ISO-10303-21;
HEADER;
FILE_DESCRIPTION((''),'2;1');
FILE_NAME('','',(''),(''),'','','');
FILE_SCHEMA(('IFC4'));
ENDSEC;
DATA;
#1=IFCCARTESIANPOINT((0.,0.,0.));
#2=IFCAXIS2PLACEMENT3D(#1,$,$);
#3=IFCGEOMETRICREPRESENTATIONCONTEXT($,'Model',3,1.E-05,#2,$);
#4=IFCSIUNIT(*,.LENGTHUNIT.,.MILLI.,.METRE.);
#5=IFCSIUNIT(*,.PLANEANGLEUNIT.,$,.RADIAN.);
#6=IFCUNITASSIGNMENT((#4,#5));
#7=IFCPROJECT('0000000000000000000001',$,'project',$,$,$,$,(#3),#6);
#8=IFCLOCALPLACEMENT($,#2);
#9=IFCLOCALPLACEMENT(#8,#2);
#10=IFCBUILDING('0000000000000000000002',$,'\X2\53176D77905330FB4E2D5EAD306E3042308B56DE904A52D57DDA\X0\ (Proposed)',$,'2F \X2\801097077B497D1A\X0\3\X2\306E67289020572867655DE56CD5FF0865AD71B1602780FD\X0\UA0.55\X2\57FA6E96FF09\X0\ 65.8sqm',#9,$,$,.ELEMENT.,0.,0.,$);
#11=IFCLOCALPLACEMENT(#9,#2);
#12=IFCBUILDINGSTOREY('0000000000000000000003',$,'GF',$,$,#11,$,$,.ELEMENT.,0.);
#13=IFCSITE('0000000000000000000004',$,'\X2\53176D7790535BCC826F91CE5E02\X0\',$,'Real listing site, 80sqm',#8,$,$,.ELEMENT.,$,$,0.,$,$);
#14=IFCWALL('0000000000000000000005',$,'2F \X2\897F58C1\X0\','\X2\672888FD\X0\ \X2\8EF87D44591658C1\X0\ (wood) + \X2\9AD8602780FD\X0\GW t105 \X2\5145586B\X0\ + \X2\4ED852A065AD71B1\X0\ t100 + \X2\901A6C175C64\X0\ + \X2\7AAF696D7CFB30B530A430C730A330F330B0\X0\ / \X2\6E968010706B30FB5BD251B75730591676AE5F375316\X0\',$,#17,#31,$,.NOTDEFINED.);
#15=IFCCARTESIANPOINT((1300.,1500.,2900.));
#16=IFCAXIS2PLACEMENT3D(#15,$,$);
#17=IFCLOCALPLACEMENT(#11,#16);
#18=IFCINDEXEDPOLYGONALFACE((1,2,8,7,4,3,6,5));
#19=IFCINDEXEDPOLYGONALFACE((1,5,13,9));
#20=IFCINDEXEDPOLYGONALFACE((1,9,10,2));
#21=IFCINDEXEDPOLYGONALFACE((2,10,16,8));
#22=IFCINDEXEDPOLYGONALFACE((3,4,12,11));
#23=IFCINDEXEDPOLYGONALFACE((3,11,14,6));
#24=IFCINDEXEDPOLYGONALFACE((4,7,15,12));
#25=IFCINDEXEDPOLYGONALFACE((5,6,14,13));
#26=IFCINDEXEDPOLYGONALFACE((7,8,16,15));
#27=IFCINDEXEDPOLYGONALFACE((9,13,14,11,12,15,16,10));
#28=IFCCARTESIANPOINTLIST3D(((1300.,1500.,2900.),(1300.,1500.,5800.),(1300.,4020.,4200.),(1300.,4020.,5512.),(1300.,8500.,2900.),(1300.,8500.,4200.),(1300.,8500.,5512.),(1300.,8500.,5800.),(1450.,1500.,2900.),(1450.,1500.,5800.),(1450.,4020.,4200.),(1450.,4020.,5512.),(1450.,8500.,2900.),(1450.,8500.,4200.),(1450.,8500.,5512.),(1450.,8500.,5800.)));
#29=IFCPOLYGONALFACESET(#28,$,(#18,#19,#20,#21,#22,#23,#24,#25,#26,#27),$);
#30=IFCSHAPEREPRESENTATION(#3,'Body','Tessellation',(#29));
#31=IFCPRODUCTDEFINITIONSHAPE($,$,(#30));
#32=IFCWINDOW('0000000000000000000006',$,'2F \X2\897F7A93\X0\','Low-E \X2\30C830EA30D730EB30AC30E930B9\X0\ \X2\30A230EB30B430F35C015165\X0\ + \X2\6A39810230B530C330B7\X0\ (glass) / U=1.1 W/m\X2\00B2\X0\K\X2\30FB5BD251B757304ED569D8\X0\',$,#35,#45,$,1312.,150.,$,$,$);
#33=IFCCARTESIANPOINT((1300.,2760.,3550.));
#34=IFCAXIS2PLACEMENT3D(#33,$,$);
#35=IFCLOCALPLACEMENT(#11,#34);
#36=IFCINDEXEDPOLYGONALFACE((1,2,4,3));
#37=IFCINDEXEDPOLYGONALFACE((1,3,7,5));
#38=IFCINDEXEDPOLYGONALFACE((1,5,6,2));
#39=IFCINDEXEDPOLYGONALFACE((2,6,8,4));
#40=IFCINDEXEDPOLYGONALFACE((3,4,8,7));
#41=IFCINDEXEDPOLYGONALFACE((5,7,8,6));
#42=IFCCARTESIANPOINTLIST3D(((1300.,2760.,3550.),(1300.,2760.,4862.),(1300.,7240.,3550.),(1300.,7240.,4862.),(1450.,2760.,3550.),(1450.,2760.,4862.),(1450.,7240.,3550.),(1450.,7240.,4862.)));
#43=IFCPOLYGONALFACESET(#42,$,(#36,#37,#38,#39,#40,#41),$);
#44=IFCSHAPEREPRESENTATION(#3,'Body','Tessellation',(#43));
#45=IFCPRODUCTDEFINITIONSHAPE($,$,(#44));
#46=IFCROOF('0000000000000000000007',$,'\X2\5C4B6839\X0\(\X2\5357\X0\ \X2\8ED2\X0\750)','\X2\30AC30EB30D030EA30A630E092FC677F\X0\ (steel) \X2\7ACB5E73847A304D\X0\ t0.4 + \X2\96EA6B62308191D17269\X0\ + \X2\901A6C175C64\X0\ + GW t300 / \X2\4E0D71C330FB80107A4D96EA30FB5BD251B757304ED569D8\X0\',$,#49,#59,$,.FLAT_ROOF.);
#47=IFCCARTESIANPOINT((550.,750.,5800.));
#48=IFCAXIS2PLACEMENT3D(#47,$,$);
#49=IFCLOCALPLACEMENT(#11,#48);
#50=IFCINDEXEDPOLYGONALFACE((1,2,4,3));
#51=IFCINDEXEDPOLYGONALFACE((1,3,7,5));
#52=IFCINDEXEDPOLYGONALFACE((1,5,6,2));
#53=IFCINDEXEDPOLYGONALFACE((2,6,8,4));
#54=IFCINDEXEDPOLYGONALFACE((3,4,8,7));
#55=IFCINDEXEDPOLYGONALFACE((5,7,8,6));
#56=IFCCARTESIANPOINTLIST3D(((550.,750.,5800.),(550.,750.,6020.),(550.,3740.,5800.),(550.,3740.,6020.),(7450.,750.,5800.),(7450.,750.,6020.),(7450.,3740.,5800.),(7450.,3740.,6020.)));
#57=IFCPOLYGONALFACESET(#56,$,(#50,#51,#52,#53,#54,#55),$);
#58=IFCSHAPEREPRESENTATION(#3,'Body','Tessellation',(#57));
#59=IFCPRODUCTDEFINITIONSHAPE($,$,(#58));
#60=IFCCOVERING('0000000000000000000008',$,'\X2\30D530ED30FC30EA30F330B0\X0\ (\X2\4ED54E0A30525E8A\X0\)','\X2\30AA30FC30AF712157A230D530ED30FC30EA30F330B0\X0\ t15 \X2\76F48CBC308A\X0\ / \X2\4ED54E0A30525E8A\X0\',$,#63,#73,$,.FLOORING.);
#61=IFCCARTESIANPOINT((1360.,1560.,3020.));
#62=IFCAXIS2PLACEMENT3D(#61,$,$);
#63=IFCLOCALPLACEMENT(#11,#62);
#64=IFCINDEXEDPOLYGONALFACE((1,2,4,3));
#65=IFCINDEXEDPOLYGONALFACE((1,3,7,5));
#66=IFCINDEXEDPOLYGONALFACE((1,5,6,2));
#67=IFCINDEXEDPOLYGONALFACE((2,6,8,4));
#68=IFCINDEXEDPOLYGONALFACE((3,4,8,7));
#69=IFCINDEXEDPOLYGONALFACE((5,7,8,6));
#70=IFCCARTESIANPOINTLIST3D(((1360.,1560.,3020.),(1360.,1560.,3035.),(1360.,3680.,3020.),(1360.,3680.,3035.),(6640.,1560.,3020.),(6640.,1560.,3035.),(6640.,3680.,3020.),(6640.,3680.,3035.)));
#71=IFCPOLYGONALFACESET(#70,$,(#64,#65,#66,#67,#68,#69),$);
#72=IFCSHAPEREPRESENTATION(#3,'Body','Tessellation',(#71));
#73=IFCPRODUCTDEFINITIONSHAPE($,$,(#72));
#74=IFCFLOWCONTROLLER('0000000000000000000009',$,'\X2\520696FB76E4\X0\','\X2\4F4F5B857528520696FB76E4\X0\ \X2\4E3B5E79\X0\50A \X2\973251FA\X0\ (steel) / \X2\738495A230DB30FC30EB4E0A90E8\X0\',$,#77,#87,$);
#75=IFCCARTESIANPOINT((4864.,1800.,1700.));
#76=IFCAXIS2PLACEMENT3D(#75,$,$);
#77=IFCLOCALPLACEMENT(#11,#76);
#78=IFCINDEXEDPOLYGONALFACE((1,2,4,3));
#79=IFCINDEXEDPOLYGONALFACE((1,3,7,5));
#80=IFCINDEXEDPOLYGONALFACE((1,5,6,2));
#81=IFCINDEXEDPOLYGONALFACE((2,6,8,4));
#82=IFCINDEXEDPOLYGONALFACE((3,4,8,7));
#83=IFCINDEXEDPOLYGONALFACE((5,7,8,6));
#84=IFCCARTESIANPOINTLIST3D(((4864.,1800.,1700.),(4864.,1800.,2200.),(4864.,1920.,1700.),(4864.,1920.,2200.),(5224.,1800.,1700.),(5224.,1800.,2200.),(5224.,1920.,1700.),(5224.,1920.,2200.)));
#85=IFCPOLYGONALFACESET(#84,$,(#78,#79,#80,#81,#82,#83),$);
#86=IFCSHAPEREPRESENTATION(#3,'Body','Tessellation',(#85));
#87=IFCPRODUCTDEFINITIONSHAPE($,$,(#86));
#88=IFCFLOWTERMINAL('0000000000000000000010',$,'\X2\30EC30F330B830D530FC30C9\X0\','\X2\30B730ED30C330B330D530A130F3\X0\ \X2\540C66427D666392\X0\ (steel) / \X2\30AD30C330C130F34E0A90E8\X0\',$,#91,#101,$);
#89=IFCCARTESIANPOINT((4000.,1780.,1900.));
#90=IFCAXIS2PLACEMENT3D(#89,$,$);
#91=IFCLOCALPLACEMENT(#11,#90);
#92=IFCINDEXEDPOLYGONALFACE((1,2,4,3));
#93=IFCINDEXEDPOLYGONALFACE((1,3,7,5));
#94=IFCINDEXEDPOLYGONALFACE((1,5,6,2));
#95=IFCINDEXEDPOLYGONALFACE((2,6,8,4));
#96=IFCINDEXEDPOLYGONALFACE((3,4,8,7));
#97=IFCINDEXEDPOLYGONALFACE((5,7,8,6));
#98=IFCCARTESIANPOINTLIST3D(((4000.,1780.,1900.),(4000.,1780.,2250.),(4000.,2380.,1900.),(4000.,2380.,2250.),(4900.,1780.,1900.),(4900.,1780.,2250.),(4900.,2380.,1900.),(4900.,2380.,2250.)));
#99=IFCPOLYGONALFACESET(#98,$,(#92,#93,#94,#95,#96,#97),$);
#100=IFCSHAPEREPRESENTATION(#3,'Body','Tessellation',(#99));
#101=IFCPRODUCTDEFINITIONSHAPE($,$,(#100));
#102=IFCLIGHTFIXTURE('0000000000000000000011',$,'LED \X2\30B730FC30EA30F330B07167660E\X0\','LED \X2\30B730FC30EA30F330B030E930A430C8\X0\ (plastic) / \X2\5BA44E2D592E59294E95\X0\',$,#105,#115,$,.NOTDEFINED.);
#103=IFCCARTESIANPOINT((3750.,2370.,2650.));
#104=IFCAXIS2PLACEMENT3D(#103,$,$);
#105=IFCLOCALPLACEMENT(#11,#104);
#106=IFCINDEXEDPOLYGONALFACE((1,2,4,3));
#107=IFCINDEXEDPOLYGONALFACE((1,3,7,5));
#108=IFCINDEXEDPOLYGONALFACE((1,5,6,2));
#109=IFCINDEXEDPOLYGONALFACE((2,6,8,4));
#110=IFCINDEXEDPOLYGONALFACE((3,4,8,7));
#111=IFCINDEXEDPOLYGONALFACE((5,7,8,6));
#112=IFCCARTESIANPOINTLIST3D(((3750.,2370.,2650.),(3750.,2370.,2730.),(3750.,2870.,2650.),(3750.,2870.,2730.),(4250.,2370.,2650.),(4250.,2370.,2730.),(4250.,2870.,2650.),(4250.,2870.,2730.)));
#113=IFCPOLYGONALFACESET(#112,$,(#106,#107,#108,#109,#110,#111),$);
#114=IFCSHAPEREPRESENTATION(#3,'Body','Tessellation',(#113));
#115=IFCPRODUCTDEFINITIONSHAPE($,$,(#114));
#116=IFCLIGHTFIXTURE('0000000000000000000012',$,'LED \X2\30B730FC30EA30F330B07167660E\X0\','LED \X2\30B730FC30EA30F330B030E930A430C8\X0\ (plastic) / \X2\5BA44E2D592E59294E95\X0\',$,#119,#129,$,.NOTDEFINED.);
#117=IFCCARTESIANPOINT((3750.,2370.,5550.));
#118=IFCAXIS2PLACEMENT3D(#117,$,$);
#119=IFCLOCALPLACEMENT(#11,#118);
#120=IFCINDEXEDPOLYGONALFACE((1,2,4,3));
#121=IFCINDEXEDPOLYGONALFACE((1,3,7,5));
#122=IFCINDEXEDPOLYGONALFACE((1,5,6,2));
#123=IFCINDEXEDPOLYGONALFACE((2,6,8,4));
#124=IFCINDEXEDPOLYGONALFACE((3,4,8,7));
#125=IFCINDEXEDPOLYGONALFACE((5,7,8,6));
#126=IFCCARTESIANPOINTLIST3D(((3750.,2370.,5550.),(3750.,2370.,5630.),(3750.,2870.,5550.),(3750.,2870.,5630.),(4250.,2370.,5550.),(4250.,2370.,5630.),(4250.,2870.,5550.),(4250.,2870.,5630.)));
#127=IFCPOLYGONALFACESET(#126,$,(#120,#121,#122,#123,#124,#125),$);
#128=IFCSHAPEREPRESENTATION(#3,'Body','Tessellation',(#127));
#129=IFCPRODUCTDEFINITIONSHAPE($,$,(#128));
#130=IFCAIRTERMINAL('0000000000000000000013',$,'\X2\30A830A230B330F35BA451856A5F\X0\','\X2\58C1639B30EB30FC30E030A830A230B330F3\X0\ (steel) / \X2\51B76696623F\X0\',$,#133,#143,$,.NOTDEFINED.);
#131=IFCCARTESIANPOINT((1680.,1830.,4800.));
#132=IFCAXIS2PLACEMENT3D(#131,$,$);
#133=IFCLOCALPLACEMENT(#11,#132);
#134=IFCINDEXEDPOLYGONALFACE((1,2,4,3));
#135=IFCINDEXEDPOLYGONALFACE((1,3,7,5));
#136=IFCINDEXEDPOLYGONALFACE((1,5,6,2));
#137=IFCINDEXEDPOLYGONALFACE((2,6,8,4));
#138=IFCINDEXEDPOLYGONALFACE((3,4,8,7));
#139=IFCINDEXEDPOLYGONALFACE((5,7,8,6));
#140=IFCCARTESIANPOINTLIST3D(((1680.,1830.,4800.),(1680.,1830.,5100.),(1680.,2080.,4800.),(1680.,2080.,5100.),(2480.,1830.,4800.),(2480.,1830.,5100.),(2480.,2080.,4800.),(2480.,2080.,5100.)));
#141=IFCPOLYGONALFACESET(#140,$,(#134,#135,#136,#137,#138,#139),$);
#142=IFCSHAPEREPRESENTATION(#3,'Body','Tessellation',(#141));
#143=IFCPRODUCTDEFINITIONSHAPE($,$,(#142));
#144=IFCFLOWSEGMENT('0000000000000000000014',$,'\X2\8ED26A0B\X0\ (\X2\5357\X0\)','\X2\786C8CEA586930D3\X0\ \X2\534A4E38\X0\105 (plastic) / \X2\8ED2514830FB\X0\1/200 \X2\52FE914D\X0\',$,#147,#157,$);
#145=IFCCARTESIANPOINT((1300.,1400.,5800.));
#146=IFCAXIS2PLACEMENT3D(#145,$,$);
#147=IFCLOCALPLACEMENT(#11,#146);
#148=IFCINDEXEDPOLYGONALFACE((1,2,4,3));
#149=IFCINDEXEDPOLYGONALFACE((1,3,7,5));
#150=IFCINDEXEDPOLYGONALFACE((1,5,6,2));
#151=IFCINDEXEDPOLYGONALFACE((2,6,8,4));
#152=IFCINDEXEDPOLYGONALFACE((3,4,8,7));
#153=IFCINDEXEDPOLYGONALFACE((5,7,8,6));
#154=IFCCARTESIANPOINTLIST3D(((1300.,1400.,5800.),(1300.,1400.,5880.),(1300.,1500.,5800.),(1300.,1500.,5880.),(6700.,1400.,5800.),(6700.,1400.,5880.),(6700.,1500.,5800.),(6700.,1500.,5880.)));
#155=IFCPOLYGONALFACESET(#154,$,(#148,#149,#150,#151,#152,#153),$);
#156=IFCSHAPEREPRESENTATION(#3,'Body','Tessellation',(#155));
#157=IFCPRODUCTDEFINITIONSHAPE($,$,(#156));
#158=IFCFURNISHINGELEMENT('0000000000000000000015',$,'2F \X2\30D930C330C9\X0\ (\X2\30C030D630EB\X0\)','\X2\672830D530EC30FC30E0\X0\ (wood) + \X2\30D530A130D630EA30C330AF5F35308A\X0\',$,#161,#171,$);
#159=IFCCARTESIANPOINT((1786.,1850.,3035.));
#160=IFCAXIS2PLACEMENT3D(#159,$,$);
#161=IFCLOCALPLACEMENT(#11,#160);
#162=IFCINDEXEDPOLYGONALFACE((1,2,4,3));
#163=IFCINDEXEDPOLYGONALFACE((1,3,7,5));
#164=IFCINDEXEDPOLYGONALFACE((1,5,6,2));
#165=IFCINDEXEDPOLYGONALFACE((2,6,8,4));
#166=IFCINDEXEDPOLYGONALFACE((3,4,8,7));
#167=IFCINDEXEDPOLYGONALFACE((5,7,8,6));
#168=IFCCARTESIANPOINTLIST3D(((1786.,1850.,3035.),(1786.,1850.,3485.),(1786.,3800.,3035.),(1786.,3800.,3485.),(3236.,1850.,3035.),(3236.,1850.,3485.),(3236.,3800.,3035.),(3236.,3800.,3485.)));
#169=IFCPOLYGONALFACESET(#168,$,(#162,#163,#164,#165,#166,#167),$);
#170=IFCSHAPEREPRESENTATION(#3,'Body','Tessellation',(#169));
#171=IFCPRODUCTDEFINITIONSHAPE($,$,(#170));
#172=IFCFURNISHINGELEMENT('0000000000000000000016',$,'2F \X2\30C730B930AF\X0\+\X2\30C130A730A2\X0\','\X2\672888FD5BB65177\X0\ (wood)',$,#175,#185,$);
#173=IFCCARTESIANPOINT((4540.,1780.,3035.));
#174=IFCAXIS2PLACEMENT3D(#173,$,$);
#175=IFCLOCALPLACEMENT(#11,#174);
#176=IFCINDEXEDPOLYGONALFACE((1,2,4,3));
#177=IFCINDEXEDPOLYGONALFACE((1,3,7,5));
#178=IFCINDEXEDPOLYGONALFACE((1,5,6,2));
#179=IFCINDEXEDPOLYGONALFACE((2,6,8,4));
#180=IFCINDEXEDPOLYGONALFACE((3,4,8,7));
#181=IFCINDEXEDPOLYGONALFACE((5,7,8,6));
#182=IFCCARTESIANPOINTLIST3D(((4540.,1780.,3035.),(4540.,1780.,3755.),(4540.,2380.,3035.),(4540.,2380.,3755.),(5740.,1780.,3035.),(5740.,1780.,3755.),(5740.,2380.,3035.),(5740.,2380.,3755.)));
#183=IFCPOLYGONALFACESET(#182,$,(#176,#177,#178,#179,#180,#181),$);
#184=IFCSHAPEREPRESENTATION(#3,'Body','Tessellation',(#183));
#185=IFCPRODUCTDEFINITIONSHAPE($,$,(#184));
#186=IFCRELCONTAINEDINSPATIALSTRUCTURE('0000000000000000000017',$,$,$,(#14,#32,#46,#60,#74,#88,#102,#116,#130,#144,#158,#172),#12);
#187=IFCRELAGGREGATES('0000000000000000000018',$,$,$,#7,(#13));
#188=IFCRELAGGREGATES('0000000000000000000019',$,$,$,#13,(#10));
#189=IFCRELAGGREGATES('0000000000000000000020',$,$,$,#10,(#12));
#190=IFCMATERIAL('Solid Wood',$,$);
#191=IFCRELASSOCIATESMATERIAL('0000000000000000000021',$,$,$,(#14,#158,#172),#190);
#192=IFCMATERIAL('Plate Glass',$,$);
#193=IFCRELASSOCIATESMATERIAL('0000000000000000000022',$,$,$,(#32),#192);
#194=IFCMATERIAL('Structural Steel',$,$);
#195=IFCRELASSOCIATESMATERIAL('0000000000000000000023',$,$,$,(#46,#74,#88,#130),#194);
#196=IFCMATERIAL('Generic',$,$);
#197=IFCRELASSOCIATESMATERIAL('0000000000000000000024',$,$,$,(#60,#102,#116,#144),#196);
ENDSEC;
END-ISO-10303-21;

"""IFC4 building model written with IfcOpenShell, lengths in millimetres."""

from ifc_helpers import new_model, si_unit, frame, frame_2d, origin, place, context, project, spatial, rectangle, extrude, material, element, fill, save


model = new_model("IFC4")

# Units and contexts
model_context = context("Model", 3, precision=1e-05, world=origin())
ifc_project = project(units=[si_unit("LENGTHUNIT", "METRE", prefix="MILLI"), si_unit("PLANEANGLEUNIT", "RADIAN")], contexts=[model_context])

# Site, building, storey
site_placement = place(None, origin())
site = spatial("IfcSite", under=ifc_project, at=site_placement, Name="北海道富良野市", ObjectType="Real listing site, 80sqm", CompositionType="ELEMENT", RefElevation=0.0)
building_placement = place(site_placement, origin())
building = spatial("IfcBuilding", under=site, at=building_placement, Name="北海道・中庭のある回遊動線 (Proposed)", ObjectType="2F 耐震等級3の木造在来工法（断熱性能UA0.55基準） 65.8sqm", CompositionType="ELEMENT", ElevationOfRefHeight=0.0, ElevationOfTerrain=0.0)
storey_placement = place(building_placement, origin())
storey = spatial("IfcBuildingStorey", under=building, at=storey_placement, Name="GF", CompositionType="ELEMENT", Elevation=0.0)

# Shared definitions
ifc_material_1 = material(Name="Solid Wood")

# Wall, opening, window
ifc_material_2 = material(Name="Plate Glass")
wall_1_placement = place(storey_placement, frame((1300.0, 1500.0, 2900.0)))
wall_1 = element("IfcWall", 1, at=wall_1_placement, inside=storey, material=ifc_material_1, Name="2F 西壁", Description="木製 軸組外壁 (wood) + 高性能GW t105 充填 + 付加断熱 t100 + 通気層 + 窯業系サイディング / 準耐火・寒冷地外皮強化", PredefinedType="NOTDEFINED", context=model_context, shape_type="SweptSolid", body=[
    extrude(rectangle(XDim=150.0, YDim=7000.0, at=frame_2d((75.0, 3500.0))), frame((1300.0, 1500.0, 2900.0)), (0.0, 0.0, 1.0), 2900.0),
])
opening_1_placement = place(storey_placement, frame((1300.0, 2760.0, 3550.0)))
opening_1 = element("IfcOpeningElement", 2, at=opening_1_placement, cuts=wall_1, PredefinedType="NOTDEFINED", context=model_context, shape_type="SweptSolid", body=[
    extrude(rectangle(XDim=150.0, YDim=4480.0, at=frame_2d((75.0, 2240.0))), frame((1300.0, 2760.0, 3550.0)), (0.0, 0.0, 1.0), 1312.0),
])
window_1_placement = place(storey_placement, frame((1300.0, 2760.0, 3550.0)))
window_1 = element("IfcWindow", 3, at=window_1_placement, inside=storey, material=ifc_material_2, Name="2F 西窓", Description="Low-E トリプルガラス アルゴン封入 + 樹脂サッシ (glass) / U=1.1 W/m²K・寒冷地仕様", OverallHeight=1312.0, OverallWidth=150.0, context=model_context, shape_type="SweptSolid", body=[
    extrude(rectangle(XDim=150.0, YDim=4480.0, at=frame_2d((75.0, 2240.0))), frame((1300.0, 2760.0, 3550.0)), (0.0, 0.0, 1.0), 1312.0),
])
fill(opening_1, window_1)

# Roof
ifc_material_3 = material(Name="Structural Steel")
for number, where, name in (
    (4, (550.0, 750.0, 5800.0), "屋根(南 軒750)"),
):
    element("IfcRoof", number, at=place(storey_placement, frame(where)), inside=storey, material=ifc_material_3, Name=name, Description="ガルバリウム鋼板 (steel) 立平葺き t0.4 + 雪止め金物 + 通気層 + GW t300 / 不燃・耐積雪・寒冷地仕様", PredefinedType="FLAT_ROOF", context=model_context, shape_type="SweptSolid", body=[
        extrude(rectangle(XDim=6900.0, YDim=2990.0, at=frame_2d((3450.0, 1495.0))), frame((550.0, 750.0, 5800.0)), (0.0, 0.0, 1.0), 220.0),
    ])

# Covering
ifc_material_4 = material(Name="Generic")
covering_placement = place(storey_placement, frame((1360.0, 1560.0, 3020.0)))
element("IfcCovering", 5, at=covering_placement, inside=storey, material=ifc_material_4, Name="フローリング (仕上げ床)", Description="オーク無垢フローリング t15 直貼り / 仕上げ床", PredefinedType="FLOORING", context=model_context, shape_type="SweptSolid", body=[
    extrude(rectangle(XDim=5280.0, YDim=2120.0, at=frame_2d((2640.0, 1060.0))), frame((1360.0, 1560.0, 3020.0)), (0.0, 0.0, 1.0), 15.0),
])

# Flow controller
flow_controller_placement = place(storey_placement, frame((4864.0, 1800.0, 1700.0)))
element("IfcFlowController", 6, at=flow_controller_placement, inside=storey, material=ifc_material_3, Name="分電盤", Description="住宅用分電盤 主幹50A 露出 (steel) / 玄関ホール上部", context=model_context, shape_type="SweptSolid", body=[
    extrude(rectangle(XDim=360.0, YDim=120.0, at=frame_2d((180.0, 60.0))), frame((4864.0, 1800.0, 1700.0)), (0.0, 0.0, 1.0), 500.0),
])

# Flow terminal
flow_terminal_placement = place(storey_placement, frame((4000.0, 1780.0, 1900.0)))
element("IfcFlowTerminal", 7, at=flow_terminal_placement, inside=storey, material=ifc_material_3, Name="レンジフード", Description="シロッコファン 同時給排 (steel) / キッチン上部", context=model_context, shape_type="SweptSolid", body=[
    extrude(rectangle(XDim=900.0, YDim=600.0, at=frame_2d((450.0, 300.0))), frame((4000.0, 1780.0, 1900.0)), (0.0, 0.0, 1.0), 350.0),
])

# Light fixtures
light_fixture_1_placement = place(storey_placement, frame((3750.0, 2370.0, 2650.0)))
element("IfcLightFixture", 8, at=light_fixture_1_placement, inside=storey, material=ifc_material_4, Name="LED シーリング照明", Description="LED シーリングライト (plastic) / 室中央天井", PredefinedType="NOTDEFINED", context=model_context, shape_type="SweptSolid", body=[
    extrude(rectangle(XDim=500.0, YDim=500.0, at=frame_2d((250.0, 250.0))), frame((3750.0, 2370.0, 2650.0)), (0.0, 0.0, 1.0), 80.0),
])
light_fixture_2_placement = place(storey_placement, frame((3750.0, 2370.0, 5550.0)))
element("IfcLightFixture", 9, at=light_fixture_2_placement, inside=storey, material=ifc_material_4, Name="LED シーリング照明", Description="LED シーリングライト (plastic) / 室中央天井", PredefinedType="NOTDEFINED", context=model_context, shape_type="SweptSolid", body=[
    extrude(rectangle(XDim=500.0, YDim=500.0, at=frame_2d((250.0, 250.0))), frame((3750.0, 2370.0, 5550.0)), (0.0, 0.0, 1.0), 80.0),
])

# Air terminal
air_terminal_placement = place(storey_placement, frame((1680.0, 1830.0, 4800.0)))
element("IfcAirTerminal", 10, at=air_terminal_placement, inside=storey, material=ifc_material_3, Name="エアコン室内機", Description="壁掛ルームエアコン (steel) / 冷暖房", PredefinedType="NOTDEFINED", context=model_context, shape_type="SweptSolid", body=[
    extrude(rectangle(XDim=800.0, YDim=250.0, at=frame_2d((400.0, 125.0))), frame((1680.0, 1830.0, 4800.0)), (0.0, 0.0, 1.0), 300.0),
])

# Flow segment
flow_segment_placement = place(storey_placement, frame((1300.0, 1400.0, 5800.0)))
element("IfcFlowSegment", 11, at=flow_segment_placement, inside=storey, material=ifc_material_4, Name="軒樋 (南)", Description="硬質塩ビ 半丸105 (plastic) / 軒先・1/200 勾配", context=model_context, shape_type="SweptSolid", body=[
    extrude(rectangle(XDim=5400.0, YDim=100.0, at=frame_2d((2700.0, 50.0))), frame((1300.0, 1400.0, 5800.0)), (0.0, 0.0, 1.0), 80.0),
])

# Furnishing elements
furnishing_1_placement = place(storey_placement, frame((1786.0, 1850.0, 3035.0)))
element("IfcFurnishingElement", 12, at=furnishing_1_placement, inside=storey, material=ifc_material_1, Name="2F ベッド (ダブル)", Description="木フレーム (wood) + ファブリック張り", context=model_context, shape_type="SweptSolid", body=[
    extrude(rectangle(XDim=1450.0, YDim=1950.0, at=frame_2d((725.0, 975.0))), frame((1786.0, 1850.0, 3035.0)), (0.0, 0.0, 1.0), 450.0),
])
furnishing_2_placement = place(storey_placement, frame((4540.0, 1780.0, 3035.0)))
element("IfcFurnishingElement", 13, at=furnishing_2_placement, inside=storey, material=ifc_material_1, Name="2F デスク+チェア", Description="木製家具 (wood)", context=model_context, shape_type="SweptSolid", body=[
    extrude(rectangle(XDim=1200.0, YDim=600.0, at=frame_2d((600.0, 300.0))), frame((4540.0, 1780.0, 3035.0)), (0.0, 0.0, 1.0), 720.0),
])

save(model, "model.ifc")
